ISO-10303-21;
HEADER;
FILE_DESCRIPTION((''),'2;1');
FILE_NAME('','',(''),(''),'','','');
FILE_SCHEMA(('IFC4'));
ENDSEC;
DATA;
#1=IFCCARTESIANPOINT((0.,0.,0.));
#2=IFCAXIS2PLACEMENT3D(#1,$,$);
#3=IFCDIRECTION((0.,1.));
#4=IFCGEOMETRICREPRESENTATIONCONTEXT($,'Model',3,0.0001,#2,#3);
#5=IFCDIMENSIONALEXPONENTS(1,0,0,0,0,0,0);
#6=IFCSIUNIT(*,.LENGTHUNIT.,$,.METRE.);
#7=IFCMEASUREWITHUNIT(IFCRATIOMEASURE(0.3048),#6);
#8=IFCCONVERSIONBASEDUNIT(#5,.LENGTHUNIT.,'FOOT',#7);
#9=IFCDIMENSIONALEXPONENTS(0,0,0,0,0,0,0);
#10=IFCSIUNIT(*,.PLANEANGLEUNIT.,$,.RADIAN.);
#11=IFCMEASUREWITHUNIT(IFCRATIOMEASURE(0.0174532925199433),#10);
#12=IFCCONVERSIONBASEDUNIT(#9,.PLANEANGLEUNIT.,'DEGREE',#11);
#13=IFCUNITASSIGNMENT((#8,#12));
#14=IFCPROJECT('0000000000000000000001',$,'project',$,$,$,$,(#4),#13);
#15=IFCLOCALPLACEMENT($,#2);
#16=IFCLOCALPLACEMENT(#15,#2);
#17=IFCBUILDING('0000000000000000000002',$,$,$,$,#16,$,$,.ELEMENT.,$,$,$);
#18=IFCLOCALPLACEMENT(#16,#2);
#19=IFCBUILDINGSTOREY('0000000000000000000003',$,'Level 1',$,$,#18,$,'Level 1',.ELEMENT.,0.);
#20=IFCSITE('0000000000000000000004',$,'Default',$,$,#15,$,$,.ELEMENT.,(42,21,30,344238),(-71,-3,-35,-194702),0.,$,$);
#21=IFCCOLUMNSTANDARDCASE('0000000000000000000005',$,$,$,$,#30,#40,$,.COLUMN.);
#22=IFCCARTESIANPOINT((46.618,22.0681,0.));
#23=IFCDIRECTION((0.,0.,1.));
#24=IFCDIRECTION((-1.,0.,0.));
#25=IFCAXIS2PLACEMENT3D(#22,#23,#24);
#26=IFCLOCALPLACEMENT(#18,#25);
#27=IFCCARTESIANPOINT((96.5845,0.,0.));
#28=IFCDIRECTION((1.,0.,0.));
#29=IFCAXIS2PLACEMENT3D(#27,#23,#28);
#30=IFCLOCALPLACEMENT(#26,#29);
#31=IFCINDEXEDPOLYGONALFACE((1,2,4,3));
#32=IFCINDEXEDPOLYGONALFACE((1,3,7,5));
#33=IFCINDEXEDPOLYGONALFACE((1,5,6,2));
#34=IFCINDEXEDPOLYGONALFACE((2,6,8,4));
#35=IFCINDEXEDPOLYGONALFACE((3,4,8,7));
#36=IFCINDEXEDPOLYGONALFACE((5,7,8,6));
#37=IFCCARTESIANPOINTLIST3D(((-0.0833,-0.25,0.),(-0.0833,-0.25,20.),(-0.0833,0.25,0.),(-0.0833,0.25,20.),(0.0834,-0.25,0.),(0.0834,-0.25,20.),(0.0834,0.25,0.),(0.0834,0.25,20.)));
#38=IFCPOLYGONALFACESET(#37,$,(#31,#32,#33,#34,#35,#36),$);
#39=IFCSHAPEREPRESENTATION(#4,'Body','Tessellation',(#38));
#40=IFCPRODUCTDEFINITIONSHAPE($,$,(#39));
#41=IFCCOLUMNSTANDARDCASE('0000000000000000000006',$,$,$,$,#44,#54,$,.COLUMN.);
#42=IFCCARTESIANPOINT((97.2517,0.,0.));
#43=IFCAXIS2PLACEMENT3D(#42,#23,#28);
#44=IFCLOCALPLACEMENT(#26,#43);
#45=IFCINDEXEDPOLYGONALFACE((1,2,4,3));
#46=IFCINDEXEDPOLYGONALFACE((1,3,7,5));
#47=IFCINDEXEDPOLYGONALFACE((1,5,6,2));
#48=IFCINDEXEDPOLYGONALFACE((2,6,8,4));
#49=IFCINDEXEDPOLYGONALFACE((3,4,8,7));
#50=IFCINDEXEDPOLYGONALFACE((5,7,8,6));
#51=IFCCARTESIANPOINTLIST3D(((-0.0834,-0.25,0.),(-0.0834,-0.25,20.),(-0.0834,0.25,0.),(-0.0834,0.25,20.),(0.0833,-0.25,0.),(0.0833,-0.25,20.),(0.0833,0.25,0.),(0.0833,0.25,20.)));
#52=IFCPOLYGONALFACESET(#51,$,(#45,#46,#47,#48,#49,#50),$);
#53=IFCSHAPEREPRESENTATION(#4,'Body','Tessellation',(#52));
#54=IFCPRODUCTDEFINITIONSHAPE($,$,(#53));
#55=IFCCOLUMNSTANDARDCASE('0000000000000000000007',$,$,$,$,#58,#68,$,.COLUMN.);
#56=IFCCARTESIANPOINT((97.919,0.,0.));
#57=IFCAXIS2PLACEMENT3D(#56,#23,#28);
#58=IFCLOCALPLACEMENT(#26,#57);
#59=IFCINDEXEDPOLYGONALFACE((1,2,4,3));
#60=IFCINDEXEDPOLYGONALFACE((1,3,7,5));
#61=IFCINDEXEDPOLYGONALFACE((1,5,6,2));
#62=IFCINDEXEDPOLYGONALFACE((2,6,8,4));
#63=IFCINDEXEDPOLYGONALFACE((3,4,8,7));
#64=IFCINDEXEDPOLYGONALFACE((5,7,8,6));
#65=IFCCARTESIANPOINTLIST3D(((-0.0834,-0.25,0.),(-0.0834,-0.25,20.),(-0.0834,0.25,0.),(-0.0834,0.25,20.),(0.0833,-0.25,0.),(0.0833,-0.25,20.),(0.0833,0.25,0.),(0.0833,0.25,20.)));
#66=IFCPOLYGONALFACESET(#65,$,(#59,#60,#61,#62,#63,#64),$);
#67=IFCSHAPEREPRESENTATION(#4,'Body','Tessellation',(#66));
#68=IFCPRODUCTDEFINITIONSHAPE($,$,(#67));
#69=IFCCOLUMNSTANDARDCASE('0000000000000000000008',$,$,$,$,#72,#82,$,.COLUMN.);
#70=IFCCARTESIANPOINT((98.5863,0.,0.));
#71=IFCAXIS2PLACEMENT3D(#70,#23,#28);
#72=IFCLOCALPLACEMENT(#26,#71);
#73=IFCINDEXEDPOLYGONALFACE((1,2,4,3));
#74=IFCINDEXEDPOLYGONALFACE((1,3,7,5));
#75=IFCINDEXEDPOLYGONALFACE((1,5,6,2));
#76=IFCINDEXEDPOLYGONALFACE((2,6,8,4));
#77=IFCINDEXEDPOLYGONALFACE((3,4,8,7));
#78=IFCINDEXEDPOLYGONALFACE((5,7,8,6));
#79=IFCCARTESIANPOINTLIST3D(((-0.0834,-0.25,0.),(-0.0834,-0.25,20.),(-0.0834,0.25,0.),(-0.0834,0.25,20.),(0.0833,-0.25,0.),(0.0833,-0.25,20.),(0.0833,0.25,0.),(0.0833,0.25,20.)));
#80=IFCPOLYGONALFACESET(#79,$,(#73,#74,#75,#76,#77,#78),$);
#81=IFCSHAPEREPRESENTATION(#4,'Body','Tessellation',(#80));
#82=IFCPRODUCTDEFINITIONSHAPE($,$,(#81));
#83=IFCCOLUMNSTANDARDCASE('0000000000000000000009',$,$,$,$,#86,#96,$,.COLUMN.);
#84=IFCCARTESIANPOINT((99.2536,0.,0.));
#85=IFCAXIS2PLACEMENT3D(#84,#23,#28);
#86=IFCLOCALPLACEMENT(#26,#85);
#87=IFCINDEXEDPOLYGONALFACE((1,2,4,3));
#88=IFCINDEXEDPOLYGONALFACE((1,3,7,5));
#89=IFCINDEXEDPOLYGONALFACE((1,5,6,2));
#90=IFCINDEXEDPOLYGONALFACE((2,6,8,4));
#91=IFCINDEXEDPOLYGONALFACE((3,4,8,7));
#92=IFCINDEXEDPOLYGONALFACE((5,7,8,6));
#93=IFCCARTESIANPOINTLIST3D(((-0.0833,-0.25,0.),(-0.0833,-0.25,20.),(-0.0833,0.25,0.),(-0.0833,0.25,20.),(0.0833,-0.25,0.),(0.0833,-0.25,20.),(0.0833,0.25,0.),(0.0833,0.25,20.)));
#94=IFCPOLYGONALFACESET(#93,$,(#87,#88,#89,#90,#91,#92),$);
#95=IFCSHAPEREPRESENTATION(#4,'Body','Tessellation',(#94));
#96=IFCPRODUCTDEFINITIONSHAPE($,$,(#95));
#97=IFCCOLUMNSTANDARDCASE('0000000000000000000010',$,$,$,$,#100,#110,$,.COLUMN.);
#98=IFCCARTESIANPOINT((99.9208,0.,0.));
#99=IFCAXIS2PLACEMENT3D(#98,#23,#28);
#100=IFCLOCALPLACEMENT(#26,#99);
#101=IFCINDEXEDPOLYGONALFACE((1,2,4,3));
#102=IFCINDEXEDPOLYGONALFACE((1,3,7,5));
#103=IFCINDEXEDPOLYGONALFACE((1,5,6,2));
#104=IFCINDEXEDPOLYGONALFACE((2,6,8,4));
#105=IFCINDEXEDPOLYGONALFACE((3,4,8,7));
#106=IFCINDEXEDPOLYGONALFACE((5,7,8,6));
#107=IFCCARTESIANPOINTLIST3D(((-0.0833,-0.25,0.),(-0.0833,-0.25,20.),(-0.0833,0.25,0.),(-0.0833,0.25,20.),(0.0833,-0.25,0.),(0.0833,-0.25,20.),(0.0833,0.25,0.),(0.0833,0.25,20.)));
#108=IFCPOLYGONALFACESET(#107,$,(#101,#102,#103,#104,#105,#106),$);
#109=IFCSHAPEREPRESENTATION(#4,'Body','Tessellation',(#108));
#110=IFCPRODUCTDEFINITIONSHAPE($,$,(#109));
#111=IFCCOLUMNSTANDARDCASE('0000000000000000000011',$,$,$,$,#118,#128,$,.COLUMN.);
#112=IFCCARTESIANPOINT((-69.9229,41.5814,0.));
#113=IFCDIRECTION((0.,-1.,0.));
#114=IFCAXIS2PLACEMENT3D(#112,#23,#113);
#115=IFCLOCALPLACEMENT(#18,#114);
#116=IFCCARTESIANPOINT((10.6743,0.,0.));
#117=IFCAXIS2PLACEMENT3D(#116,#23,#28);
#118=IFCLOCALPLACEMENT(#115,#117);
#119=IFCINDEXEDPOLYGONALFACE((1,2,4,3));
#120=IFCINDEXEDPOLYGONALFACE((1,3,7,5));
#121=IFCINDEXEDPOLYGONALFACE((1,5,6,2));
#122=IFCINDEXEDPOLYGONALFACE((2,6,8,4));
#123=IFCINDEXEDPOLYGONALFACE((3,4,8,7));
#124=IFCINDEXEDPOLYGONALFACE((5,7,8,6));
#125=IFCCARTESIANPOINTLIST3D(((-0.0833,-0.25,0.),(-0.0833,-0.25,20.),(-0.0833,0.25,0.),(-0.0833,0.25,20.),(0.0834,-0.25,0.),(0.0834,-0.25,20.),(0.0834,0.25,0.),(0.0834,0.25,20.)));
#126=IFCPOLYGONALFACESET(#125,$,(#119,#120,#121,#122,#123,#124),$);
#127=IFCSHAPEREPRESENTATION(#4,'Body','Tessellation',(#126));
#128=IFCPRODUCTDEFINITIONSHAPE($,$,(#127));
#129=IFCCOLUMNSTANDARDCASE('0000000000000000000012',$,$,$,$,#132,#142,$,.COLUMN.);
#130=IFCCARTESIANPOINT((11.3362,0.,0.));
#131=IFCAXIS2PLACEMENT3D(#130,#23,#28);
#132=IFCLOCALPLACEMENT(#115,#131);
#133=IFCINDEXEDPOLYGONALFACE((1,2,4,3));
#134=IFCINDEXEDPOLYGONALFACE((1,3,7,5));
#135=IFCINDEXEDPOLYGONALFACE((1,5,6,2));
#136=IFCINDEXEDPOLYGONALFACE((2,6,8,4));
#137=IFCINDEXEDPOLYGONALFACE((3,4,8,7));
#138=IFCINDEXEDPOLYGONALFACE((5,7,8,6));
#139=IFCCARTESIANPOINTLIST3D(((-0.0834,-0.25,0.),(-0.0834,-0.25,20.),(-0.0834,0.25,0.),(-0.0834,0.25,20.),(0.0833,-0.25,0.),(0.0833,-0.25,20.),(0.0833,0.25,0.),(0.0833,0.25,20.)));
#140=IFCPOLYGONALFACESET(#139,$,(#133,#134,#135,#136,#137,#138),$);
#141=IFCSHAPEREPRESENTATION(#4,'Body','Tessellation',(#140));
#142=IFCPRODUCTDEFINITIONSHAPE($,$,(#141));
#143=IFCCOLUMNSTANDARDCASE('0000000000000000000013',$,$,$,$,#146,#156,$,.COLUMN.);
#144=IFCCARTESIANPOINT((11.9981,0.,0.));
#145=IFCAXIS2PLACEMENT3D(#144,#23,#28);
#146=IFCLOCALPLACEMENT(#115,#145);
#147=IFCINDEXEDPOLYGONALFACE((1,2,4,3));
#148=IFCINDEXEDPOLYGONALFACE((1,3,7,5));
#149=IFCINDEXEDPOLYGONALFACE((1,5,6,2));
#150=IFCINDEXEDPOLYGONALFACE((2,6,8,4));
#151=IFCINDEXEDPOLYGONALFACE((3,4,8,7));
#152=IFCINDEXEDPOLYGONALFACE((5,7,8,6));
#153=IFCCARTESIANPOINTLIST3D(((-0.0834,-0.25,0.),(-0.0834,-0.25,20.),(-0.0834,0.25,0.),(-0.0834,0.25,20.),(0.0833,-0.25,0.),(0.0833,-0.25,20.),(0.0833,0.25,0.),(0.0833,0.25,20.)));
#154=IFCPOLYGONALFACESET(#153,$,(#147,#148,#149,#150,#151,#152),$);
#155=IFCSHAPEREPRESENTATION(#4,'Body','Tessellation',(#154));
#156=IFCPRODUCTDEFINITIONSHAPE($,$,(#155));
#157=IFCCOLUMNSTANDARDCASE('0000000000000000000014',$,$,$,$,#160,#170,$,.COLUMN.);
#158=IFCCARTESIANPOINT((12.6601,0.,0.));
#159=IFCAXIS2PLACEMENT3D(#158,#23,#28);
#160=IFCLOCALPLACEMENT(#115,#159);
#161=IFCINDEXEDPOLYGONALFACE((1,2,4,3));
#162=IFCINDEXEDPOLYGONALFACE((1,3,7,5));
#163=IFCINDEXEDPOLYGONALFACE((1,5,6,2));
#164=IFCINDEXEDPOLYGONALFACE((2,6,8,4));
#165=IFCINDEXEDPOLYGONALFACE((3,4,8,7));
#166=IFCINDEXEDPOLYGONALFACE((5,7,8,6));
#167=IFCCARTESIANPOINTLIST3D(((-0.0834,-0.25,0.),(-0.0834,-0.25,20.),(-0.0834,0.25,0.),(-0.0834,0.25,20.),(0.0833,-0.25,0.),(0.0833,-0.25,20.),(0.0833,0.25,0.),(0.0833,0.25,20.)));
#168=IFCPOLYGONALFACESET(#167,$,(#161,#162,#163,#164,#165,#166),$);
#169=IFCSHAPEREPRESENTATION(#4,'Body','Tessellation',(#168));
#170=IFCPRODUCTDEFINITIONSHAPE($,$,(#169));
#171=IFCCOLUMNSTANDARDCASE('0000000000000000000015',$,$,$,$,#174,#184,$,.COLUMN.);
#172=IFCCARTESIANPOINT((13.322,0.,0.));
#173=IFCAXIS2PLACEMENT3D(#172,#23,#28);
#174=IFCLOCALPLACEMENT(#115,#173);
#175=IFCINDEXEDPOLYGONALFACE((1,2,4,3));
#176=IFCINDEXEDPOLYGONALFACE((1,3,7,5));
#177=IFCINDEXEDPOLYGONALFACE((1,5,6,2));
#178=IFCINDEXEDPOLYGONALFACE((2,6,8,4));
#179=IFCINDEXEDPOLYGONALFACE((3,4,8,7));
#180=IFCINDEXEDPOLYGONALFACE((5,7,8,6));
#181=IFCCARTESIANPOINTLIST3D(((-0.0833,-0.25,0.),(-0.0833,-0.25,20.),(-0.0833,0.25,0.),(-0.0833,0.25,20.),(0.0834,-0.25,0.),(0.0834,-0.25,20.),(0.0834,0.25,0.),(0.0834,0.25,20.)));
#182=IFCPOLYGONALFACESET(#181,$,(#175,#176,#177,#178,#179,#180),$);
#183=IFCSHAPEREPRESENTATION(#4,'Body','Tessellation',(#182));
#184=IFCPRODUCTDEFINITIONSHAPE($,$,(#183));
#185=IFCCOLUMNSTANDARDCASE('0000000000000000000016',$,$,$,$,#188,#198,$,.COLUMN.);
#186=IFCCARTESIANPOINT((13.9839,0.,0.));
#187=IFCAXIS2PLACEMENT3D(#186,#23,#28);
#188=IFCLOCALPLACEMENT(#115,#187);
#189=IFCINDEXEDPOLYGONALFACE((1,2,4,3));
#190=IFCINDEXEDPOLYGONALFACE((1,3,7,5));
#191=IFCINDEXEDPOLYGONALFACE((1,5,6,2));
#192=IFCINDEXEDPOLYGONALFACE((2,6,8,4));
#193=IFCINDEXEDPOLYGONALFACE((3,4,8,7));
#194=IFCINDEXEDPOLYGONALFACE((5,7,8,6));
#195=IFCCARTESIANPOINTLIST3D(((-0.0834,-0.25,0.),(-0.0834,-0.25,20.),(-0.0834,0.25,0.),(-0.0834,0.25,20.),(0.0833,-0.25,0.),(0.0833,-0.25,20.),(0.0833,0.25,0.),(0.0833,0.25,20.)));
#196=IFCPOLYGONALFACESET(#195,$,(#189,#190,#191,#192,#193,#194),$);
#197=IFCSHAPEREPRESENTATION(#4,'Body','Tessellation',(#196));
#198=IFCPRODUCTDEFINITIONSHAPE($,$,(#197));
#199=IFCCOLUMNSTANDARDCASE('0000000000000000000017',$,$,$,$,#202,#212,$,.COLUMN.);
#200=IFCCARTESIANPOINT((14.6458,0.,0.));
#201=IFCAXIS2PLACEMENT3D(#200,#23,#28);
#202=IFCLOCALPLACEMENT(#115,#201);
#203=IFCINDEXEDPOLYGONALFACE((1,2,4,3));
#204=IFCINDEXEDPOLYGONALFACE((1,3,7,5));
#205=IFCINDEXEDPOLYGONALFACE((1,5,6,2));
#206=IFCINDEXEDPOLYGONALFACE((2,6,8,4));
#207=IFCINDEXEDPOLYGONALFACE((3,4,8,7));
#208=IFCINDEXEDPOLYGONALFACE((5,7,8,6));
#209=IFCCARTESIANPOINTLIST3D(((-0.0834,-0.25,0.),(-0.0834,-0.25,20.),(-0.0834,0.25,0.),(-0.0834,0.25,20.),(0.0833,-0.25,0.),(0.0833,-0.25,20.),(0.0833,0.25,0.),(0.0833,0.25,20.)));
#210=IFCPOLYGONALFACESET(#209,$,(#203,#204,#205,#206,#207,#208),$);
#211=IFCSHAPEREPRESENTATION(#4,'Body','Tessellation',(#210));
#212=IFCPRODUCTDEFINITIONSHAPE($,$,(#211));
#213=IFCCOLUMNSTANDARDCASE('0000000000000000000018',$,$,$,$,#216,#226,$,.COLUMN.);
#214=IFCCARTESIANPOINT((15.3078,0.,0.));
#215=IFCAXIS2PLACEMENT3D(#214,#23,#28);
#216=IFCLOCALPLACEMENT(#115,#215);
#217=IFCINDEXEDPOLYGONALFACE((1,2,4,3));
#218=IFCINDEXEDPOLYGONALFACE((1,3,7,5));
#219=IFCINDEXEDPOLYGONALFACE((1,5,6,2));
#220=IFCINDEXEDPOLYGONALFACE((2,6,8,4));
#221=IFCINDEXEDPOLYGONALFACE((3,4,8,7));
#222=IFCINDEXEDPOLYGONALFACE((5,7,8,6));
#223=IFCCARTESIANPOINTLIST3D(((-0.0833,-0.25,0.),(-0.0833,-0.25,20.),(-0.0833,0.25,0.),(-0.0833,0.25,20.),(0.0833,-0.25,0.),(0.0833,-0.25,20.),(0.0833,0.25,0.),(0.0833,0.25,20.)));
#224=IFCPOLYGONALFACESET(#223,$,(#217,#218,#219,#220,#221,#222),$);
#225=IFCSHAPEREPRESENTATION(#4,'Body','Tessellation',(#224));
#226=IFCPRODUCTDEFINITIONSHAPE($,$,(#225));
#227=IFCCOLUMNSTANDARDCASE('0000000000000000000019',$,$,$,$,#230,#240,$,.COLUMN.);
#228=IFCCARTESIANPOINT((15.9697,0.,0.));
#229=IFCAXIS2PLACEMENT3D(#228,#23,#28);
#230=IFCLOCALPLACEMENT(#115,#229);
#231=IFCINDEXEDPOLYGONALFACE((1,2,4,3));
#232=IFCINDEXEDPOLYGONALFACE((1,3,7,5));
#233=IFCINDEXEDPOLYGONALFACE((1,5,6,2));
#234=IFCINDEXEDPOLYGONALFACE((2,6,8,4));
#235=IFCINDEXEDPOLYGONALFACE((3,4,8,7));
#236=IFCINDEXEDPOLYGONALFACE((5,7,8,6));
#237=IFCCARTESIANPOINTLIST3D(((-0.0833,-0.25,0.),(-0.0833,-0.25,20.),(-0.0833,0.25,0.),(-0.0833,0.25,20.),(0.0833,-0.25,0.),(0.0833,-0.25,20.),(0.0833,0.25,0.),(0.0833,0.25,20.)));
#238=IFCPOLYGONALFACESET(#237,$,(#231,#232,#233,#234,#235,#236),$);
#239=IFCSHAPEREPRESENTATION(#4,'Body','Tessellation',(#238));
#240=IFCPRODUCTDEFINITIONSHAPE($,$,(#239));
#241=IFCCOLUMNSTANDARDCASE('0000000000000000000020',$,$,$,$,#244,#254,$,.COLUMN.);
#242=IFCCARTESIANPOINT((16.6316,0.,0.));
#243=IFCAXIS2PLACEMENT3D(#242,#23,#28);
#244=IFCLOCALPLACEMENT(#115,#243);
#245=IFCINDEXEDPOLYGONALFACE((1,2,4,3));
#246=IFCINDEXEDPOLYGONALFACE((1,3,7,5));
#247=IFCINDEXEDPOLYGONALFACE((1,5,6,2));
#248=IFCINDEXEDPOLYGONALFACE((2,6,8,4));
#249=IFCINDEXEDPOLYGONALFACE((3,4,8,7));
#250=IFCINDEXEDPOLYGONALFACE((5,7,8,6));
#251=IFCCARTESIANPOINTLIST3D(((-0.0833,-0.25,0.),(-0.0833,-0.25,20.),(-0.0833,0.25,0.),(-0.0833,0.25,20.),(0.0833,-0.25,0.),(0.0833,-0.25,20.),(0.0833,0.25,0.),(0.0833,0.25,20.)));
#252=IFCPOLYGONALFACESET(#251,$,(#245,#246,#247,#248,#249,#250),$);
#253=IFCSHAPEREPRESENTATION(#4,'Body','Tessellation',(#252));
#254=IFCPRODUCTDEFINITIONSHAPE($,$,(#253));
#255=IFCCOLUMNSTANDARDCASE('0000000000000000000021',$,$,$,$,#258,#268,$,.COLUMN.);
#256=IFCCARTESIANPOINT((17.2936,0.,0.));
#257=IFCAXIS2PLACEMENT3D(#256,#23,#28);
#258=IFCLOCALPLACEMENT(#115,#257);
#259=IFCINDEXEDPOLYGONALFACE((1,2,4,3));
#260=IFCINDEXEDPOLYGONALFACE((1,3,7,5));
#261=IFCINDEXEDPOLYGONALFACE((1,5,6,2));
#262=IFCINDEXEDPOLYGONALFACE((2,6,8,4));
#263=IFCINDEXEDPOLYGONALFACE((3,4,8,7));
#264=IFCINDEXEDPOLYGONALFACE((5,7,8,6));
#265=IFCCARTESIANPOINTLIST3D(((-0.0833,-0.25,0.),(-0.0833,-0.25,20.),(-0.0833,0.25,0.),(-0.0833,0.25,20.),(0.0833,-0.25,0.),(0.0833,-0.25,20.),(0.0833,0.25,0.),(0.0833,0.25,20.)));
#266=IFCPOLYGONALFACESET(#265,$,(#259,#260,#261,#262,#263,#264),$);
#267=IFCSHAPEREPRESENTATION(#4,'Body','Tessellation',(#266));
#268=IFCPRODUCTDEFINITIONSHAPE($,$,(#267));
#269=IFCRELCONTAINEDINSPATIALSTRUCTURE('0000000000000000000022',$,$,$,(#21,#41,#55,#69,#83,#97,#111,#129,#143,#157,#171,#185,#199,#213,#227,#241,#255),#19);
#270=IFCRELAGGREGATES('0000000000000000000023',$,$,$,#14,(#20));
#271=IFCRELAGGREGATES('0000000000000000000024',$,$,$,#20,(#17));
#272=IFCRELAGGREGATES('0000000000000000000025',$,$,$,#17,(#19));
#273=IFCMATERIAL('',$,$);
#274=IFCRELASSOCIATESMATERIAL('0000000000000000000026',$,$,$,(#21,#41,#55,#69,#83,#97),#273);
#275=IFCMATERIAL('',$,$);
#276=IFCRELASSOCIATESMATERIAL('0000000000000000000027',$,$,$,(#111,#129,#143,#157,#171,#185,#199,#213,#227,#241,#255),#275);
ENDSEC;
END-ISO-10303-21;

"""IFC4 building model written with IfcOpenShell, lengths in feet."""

from ifc_helpers import new_model, entity, si_unit, converted_unit, direction, frame, origin, place, context, project, spatial, rectangle, extrude, material, element, save


model = new_model("IFC4")

# Units and contexts
model_context = context("Model", 3, precision=0.0001, world=origin(), true_north=direction((0.0, 1.0)))
ifc_project = project(units=[converted_unit("LENGTHUNIT", "FOOT", entity("IfcRatioMeasure", 0.3048), si_unit("LENGTHUNIT", "METRE"), dimensions=[1, 0, 0, 0, 0, 0, 0]), converted_unit("PLANEANGLEUNIT", "DEGREE", entity("IfcRatioMeasure", 0.0174532925199433), si_unit("PLANEANGLEUNIT", "RADIAN"), dimensions=[0, 0, 0, 0, 0, 0, 0])], contexts=[model_context])

# Site, building, storey
site_placement = place(None, origin())
site = spatial("IfcSite", under=ifc_project, at=site_placement, Name="Default", CompositionType="ELEMENT", RefLatitude=(42, 21, 30, 344238), RefLongitude=(-71, -3, -35, -194702), RefElevation=0.0)
building_placement = place(site_placement, origin())
building = spatial("IfcBuilding", under=site, at=building_placement, CompositionType="ELEMENT")
storey_placement = place(building_placement, origin())
storey = spatial("IfcBuildingStorey", under=building, at=storey_placement, Name="Level 1", LongName="Level 1", CompositionType="ELEMENT", Elevation=0.0)

# Columns
ifc_material_1 = material(Name="")
placement_1 = place(storey_placement, frame((46.618, 22.0681, 0.0), z_axis=(0.0, 0.0, 1.0), x_axis=(-1.0, 0.0, 0.0)))
for number, where, z_axis, x_axis in (
    (1, (96.5845, 0.0, 0.0), (0.0, 0.0, 1.0), (1.0, 0.0, 0.0)),
    (2, (97.2517, 0.0, 0.0), (0.0, 0.0, 1.0), (1.0, 0.0, 0.0)),
    (3, (97.919, 0.0, 0.0), (0.0, 0.0, 1.0), (1.0, 0.0, 0.0)),
    (4, (98.5863, 0.0, 0.0), (0.0, 0.0, 1.0), (1.0, 0.0, 0.0)),
    (5, (99.2536, 0.0, 0.0), (0.0, 0.0, 1.0), (1.0, 0.0, 0.0)),
    (6, (99.9208, 0.0, 0.0), (0.0, 0.0, 1.0), (1.0, 0.0, 0.0)),
):
    element("IfcColumnStandardCase", number, at=place(placement_1, frame(where, z_axis=z_axis, x_axis=x_axis)), inside=storey, material=ifc_material_1, PredefinedType="COLUMN", context=model_context, shape_type="SweptSolid", body=[
        extrude(rectangle(XDim=0.1667, YDim=0.5), origin(), (0.0, 0.0, 1.0), 20.0),
    ])
ifc_material_2 = material(Name="")
placement_2 = place(storey_placement, frame((-69.9229, 41.5814, 0.0), z_axis=(0.0, 0.0, 1.0), x_axis=(0.0, -1.0, 0.0)))
for number, where, z_axis, x_axis in (
    (7, (10.6743, 0.0, 0.0), (0.0, 0.0, 1.0), (1.0, 0.0, 0.0)),
    (8, (11.3362, 0.0, 0.0), (0.0, 0.0, 1.0), (1.0, 0.0, 0.0)),
    (9, (11.9981, 0.0, 0.0), (0.0, 0.0, 1.0), (1.0, 0.0, 0.0)),
    (10, (12.6601, 0.0, 0.0), (0.0, 0.0, 1.0), (1.0, 0.0, 0.0)),
    (11, (13.322, 0.0, 0.0), (0.0, 0.0, 1.0), (1.0, 0.0, 0.0)),
    (12, (13.9839, 0.0, 0.0), (0.0, 0.0, 1.0), (1.0, 0.0, 0.0)),
    (13, (14.6458, 0.0, 0.0), (0.0, 0.0, 1.0), (1.0, 0.0, 0.0)),
    (14, (15.3078, 0.0, 0.0), (0.0, 0.0, 1.0), (1.0, 0.0, 0.0)),
    (15, (15.9697, 0.0, 0.0), (0.0, 0.0, 1.0), (1.0, 0.0, 0.0)),
    (16, (16.6316, 0.0, 0.0), (0.0, 0.0, 1.0), (1.0, 0.0, 0.0)),
    (17, (17.2936, 0.0, 0.0), (0.0, 0.0, 1.0), (1.0, 0.0, 0.0)),
):
    element("IfcColumnStandardCase", number, at=place(placement_2, frame(where, z_axis=z_axis, x_axis=x_axis)), inside=storey, material=ifc_material_2, PredefinedType="COLUMN", context=model_context, shape_type="SweptSolid", body=[
        extrude(rectangle(XDim=0.1667, YDim=0.5), origin(), (0.0, 0.0, 1.0), 20.0),
    ])

save(model, "model.ifc")
